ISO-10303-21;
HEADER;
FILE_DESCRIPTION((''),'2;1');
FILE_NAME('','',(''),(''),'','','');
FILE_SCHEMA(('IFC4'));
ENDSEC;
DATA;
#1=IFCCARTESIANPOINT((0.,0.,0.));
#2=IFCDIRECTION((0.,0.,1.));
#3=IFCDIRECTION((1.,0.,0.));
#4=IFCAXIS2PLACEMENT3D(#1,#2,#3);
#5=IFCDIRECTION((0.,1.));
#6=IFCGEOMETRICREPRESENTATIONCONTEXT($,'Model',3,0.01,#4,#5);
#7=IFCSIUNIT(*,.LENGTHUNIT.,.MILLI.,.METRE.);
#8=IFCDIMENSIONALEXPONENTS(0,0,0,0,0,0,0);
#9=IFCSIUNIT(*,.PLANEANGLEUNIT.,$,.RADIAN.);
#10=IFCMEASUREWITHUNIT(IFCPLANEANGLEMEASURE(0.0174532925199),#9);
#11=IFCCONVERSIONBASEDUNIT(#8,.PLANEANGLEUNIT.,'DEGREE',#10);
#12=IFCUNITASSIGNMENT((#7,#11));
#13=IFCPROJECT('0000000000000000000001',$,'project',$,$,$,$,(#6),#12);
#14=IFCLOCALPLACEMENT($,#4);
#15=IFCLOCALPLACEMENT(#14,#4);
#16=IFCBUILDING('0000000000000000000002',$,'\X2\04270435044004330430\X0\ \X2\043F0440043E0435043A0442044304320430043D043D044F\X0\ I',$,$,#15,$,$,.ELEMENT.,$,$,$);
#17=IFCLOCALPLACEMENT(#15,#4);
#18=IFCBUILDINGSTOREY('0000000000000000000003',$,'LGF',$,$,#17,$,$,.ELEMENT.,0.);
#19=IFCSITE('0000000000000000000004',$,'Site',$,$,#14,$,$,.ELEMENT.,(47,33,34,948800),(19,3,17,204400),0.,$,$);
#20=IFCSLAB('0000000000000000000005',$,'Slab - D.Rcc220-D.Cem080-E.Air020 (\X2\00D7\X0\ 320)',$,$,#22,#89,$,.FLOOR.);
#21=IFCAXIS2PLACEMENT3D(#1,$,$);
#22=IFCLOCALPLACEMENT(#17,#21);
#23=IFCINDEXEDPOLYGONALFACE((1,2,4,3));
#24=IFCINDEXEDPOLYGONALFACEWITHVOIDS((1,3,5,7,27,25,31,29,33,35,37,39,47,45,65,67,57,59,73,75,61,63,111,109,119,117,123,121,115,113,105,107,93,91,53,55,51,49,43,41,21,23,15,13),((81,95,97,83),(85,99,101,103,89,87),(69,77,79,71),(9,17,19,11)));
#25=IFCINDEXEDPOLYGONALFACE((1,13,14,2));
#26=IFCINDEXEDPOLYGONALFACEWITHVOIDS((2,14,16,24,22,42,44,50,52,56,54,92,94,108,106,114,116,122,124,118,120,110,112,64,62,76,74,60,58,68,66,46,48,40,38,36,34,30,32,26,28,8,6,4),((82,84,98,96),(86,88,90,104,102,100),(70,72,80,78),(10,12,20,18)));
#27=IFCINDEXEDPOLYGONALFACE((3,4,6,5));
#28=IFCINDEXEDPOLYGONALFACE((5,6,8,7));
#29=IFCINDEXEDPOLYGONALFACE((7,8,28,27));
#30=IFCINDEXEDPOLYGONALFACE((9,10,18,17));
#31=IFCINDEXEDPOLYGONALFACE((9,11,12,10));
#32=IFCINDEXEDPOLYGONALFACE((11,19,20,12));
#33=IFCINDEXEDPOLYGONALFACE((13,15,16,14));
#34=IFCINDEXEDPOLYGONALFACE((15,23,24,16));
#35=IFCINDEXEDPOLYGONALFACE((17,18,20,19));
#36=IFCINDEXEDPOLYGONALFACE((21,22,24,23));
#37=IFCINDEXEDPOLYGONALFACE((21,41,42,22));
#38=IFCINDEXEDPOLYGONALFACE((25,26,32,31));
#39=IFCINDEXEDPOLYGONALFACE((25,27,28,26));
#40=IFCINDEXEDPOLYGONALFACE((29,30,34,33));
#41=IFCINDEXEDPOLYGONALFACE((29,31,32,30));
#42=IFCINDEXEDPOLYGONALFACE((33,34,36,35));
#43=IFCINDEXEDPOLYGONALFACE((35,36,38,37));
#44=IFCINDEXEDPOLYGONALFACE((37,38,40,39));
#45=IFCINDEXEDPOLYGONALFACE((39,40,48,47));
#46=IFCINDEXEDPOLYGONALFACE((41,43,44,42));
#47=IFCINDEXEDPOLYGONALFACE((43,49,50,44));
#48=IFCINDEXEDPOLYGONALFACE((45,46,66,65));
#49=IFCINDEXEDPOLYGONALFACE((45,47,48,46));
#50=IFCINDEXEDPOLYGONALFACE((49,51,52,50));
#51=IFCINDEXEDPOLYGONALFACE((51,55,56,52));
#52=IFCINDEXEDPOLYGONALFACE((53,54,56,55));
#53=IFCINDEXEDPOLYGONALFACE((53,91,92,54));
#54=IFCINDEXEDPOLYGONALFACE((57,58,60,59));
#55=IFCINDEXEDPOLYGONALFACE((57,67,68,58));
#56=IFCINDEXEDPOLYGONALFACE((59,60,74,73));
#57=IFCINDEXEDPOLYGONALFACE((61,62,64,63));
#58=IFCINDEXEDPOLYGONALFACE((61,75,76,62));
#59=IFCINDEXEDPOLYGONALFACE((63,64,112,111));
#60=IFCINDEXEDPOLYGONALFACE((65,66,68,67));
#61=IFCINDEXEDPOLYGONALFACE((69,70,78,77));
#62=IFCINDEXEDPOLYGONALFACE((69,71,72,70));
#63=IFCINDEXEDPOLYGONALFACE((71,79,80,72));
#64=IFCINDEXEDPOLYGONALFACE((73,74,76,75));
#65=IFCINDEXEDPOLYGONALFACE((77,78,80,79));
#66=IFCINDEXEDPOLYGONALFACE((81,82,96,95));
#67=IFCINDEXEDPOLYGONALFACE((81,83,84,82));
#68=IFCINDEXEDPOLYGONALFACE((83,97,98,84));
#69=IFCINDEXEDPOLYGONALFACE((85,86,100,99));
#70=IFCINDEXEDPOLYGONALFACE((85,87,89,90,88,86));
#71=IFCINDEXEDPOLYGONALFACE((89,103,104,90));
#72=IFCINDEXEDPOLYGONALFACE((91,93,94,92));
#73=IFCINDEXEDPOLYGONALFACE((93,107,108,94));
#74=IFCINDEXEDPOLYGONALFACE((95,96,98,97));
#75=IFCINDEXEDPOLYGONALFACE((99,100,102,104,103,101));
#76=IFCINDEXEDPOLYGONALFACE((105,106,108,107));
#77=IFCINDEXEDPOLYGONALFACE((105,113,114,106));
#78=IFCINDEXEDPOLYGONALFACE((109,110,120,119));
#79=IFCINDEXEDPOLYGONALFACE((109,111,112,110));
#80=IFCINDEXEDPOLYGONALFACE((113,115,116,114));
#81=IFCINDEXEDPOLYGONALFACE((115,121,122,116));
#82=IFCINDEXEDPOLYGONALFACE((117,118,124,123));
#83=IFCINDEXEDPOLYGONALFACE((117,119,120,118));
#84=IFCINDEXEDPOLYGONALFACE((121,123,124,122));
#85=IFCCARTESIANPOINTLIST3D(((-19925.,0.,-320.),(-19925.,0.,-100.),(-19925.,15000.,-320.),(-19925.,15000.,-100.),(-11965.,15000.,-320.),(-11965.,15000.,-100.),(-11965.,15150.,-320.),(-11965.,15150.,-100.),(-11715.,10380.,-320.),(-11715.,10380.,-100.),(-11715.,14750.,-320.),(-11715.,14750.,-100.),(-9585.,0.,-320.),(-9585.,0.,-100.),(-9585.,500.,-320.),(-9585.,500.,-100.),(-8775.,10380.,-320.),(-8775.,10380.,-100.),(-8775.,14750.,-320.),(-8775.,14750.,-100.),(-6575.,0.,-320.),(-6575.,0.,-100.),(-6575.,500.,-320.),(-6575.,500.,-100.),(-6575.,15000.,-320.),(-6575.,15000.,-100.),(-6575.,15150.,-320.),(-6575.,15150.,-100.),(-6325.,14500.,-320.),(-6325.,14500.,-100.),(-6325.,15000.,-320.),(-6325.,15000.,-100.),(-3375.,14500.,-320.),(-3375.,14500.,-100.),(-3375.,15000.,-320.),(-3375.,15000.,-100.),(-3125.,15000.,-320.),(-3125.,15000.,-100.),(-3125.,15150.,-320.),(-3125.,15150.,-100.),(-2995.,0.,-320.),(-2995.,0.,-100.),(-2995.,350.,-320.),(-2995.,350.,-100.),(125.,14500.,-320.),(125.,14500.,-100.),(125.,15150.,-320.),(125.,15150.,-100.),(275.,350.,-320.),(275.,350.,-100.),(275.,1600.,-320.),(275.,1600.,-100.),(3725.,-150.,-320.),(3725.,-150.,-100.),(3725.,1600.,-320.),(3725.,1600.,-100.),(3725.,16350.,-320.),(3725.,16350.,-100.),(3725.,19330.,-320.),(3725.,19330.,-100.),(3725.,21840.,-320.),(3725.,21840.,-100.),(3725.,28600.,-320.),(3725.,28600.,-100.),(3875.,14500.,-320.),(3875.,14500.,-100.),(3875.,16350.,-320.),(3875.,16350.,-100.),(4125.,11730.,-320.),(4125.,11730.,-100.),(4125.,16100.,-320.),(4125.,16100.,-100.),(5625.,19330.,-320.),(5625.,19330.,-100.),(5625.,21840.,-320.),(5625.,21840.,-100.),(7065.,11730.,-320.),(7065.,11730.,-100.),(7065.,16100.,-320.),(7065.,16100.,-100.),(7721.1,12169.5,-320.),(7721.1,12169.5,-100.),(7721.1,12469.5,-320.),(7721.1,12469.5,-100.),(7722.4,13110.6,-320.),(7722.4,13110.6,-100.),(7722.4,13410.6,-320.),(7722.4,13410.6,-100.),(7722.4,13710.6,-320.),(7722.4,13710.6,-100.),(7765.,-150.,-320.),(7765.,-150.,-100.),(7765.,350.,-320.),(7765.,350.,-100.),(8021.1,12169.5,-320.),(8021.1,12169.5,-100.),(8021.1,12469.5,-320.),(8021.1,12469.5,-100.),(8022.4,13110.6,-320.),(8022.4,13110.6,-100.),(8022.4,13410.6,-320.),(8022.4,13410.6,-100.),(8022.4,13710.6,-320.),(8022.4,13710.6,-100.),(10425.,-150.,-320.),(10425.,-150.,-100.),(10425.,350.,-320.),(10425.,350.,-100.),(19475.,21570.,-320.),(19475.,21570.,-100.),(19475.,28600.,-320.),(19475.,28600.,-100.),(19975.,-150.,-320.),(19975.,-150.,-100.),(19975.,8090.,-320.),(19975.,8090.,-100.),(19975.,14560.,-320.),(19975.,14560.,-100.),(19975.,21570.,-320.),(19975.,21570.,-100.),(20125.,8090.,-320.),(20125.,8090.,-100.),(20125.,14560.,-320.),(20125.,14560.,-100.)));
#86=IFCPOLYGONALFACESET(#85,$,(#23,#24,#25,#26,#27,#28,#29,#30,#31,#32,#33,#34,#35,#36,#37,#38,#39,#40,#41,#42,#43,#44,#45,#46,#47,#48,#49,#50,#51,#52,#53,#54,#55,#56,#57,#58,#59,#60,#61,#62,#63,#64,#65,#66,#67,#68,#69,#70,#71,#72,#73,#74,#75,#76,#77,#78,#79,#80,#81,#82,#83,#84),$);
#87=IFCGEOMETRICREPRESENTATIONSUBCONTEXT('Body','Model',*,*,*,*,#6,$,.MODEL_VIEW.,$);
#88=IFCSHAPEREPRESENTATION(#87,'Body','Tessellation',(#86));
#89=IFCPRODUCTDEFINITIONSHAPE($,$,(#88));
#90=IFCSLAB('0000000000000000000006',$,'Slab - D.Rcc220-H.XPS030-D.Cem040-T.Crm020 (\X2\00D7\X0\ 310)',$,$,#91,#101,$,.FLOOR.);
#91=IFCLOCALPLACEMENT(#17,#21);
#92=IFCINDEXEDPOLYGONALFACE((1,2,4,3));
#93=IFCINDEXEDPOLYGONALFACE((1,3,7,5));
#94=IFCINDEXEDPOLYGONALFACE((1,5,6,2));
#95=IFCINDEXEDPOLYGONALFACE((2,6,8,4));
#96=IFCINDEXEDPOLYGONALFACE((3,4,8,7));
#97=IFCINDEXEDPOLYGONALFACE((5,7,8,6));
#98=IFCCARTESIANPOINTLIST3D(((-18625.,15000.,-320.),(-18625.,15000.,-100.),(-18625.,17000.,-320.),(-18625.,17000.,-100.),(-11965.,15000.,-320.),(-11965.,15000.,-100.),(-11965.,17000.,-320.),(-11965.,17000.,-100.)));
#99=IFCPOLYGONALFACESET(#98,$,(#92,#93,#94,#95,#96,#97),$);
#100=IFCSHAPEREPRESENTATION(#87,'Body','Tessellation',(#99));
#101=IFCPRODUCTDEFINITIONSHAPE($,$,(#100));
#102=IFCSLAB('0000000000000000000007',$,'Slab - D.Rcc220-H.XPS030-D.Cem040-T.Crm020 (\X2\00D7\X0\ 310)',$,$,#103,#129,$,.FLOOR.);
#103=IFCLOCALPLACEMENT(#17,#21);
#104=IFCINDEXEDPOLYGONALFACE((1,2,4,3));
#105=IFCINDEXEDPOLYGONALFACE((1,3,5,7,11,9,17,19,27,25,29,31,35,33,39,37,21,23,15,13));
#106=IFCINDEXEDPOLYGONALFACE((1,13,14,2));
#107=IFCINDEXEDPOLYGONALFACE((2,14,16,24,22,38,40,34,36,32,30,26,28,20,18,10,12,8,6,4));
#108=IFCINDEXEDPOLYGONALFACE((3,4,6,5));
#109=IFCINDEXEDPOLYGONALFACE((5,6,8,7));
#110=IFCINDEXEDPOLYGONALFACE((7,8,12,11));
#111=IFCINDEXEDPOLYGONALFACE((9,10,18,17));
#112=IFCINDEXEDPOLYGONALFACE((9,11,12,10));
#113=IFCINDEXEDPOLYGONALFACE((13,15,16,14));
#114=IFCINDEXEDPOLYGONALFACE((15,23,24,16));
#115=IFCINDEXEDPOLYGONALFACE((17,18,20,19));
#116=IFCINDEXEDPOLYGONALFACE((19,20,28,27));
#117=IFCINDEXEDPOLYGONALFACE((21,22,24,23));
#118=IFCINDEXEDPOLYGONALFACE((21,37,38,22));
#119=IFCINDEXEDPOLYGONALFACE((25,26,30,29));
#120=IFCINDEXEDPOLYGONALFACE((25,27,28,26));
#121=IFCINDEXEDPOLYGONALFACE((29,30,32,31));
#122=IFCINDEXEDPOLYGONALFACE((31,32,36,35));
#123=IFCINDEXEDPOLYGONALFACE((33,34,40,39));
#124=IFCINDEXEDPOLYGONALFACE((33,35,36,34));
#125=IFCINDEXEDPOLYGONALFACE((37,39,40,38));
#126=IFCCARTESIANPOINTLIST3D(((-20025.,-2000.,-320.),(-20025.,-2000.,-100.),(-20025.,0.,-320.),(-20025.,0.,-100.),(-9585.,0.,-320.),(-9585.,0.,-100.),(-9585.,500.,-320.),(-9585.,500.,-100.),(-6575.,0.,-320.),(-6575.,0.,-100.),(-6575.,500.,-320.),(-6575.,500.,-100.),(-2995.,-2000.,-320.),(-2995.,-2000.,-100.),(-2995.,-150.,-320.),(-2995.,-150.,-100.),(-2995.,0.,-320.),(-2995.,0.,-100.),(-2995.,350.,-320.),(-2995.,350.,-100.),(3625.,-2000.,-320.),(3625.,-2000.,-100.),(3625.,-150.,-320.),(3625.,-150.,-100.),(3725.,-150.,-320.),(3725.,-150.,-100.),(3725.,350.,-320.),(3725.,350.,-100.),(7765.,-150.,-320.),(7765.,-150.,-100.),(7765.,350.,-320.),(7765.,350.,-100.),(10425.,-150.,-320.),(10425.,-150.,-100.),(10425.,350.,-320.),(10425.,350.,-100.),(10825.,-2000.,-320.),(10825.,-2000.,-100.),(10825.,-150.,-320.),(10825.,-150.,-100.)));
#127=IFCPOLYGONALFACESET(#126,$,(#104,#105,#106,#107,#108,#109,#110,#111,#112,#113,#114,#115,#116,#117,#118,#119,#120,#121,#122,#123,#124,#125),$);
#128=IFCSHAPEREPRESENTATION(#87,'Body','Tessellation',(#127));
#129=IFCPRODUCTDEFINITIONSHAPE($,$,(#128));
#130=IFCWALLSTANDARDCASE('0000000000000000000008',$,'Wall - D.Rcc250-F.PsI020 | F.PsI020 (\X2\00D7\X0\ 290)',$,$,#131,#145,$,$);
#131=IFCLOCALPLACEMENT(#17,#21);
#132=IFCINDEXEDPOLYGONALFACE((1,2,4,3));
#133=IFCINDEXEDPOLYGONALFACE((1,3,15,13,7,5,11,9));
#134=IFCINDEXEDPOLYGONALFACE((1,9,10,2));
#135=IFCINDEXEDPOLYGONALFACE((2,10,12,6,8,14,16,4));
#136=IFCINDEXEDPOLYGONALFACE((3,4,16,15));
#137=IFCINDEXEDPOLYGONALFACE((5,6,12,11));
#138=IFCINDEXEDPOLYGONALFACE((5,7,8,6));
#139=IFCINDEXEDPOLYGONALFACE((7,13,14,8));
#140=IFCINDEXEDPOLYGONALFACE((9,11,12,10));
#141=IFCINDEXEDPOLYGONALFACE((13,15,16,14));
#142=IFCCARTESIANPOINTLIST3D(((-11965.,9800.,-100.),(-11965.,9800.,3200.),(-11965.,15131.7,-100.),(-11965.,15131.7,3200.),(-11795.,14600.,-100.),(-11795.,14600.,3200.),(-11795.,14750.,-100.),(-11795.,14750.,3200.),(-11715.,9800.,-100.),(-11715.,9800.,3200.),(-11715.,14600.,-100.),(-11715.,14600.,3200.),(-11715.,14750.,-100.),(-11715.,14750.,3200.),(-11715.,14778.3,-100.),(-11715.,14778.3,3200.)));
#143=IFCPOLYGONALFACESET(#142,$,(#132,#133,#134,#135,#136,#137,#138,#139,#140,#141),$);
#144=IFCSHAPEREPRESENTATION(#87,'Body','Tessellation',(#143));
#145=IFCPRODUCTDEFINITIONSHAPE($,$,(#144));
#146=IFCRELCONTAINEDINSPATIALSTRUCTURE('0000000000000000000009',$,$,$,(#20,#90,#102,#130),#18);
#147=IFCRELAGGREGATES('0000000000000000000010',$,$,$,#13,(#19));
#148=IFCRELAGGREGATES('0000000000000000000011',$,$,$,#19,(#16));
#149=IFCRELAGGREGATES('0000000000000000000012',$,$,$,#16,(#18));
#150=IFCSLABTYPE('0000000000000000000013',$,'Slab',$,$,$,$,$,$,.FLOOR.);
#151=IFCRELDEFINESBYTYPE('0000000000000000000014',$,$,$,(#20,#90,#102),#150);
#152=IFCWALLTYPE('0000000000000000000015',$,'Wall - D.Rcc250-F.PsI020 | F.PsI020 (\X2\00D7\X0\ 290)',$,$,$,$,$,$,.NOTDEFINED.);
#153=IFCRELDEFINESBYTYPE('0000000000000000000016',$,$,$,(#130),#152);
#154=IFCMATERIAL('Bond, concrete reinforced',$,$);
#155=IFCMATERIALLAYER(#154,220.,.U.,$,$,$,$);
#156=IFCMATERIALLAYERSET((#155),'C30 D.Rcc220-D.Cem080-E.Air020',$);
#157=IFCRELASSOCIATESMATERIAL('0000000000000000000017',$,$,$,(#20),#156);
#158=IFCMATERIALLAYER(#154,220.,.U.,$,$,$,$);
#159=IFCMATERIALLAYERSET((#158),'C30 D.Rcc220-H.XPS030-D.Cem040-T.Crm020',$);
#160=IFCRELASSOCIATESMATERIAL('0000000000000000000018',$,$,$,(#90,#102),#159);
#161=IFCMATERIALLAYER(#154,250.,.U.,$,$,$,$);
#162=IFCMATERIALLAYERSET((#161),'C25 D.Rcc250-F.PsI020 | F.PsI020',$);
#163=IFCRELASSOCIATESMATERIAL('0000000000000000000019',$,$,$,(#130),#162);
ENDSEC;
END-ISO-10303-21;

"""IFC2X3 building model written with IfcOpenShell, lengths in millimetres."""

from ifc_helpers import new_model, entity, si_unit, converted_unit, direction, frame, origin_with_axes, origin_2d_with_axis, place, context, subcontext, project, spatial, polyline, rectangle, outline, extrude, material, layer, layer_set, layer_usage, type_object, element, save


model = new_model("IFC2X3")

# Units and contexts
model_context = context("Model", 3, precision=0.01, world=origin_with_axes(), true_north=direction((0.0, 1.0)))
body_context = subcontext(model_context, "Body", "Model", "MODEL_VIEW")
ifc_project = project(units=[si_unit("LENGTHUNIT", "METRE", prefix="MILLI"), converted_unit("PLANEANGLEUNIT", "DEGREE", entity("IfcPlaneAngleMeasure", 0.0174532925199), si_unit("PLANEANGLEUNIT", "RADIAN"), dimensions=[0, 0, 0, 0, 0, 0, 0])], contexts=[model_context])

# Site, building, storey
site_placement = place(None, origin_with_axes())
site = spatial("IfcSite", under=ifc_project, at=site_placement, Name="Site", CompositionType="ELEMENT", RefLatitude=(47, 33, 34, 948800), RefLongitude=(19, 3, 17, 204400), RefElevation=0.0)
building_placement = place(site_placement, origin_with_axes())
building = spatial("IfcBuilding", under=site, at=building_placement, Name="Черга проектування I", CompositionType="ELEMENT")
storey_placement = place(building_placement, origin_with_axes())
storey = spatial("IfcBuildingStorey", under=building, at=storey_placement, Name="LGF", CompositionType="ELEMENT", Elevation=0.0)

# Shared definitions
ifc_material = material(Name="Bond, concrete reinforced")

# Slab, openings
ifc_layer_1 = layer(ifc_material, 220.0, ventilated="UNKNOWN")
ifc_layer_set_1 = layer_set([ifc_layer_1], Name="C30 D.Rcc220-D.Cem080-E.Air020")
ifc_layer_usage_1 = layer_usage(ifc_layer_set_1, "AXIS3", "NEGATIVE", 220.0)
slab_type = type_object("IfcSlabType", Name="Slab", PredefinedType="FLOOR")
slab_1_placement = place(storey_placement, frame((-19925.0, 0.0, -100.0), z_axis=(0.0, 0.0, 1.0), x_axis=(1.0, 0.0, 0.0)))
slab_1 = element("IfcSlab", 1, at=slab_1_placement, inside=storey, type_object=slab_type, material=ifc_layer_usage_1, Name="Slab - D.Rcc220-D.Cem080-E.Air020 (× 320)", PredefinedType="FLOOR", context=body_context, shape_type="SweptSolid", body=[
    extrude(outline(polyline([(0.0, 0.0), (10340.0, 0.0), (10340.0, 500.0), (13350.0, 500.0), (13350.0, 0.0), (16930.0, 0.0), (16930.0, 350.0), (20200.0, 350.0), (20200.0, 1600.0), (23650.0, 1600.0), (23650.0, -150.0), (27690.0, -150.0), (27690.0, 350.0), (30350.0, 350.0), (30350.0, -150.0), (39900.0, -150.0), (39900.0, 8090.0), (40050.0, 8090.0), (40050.0, 14560.0), (39900.0, 14560.0), (39900.0, 21570.0), (39400.0, 21570.0), (39400.0, 28600.0), (23650.0, 28600.0), (23650.0, 21840.0), (25550.0, 21840.0), (25550.0, 19330.0), (23650.0, 19330.0), (23650.0, 16350.0), (23800.0, 16350.0), (23800.0, 14500.0), (20050.0, 14500.0), (20050.0, 15150.0), (16800.0, 15150.0), (16800.0, 15000.0), (16550.0, 15000.0), (16550.0, 14500.0), (13600.0, 14500.0), (13600.0, 15000.0), (13350.0, 15000.0), (13350.0, 15150.0), (7960.0, 15150.0), (7960.0, 15000.0), (0.0, 15000.0), (0.0, 0.0)])), frame((0.0, 0.0, -220.0), z_axis=(0.0, 0.0, 1.0), x_axis=(1.0, 0.0, 0.0)), (0.0, 0.0, 1.0), 220.0),
])
opening_1_placement = place(slab_1_placement, frame((19925.0, 0.0, 100.0), z_axis=(0.0, 0.0, 1.0), x_axis=(1.0, 0.0, 0.0)))
element("IfcOpeningElement", 2, at=opening_1_placement, cuts=slab_1, ObjectType="OPENING", context=body_context, shape_type="SweptSolid", body=[
    extrude(rectangle(XDim=300.0, YDim=300.0, at=origin_2d_with_axis()), frame((7872.4, 13560.6, 320.0), z_axis=(0.0, 0.0, 1.0), x_axis=(1.0, 0.0, 0.0)), (0.0, 0.0, -1.0), 960.0),
])
opening_2_placement = place(slab_1_placement, frame((19925.0, 0.0, 100.0), z_axis=(0.0, 0.0, 1.0), x_axis=(1.0, 0.0, 0.0)))
element("IfcOpeningElement", 3, at=opening_2_placement, cuts=slab_1, ObjectType="OPENING", context=body_context, shape_type="SweptSolid", body=[
    extrude(rectangle(XDim=300.0, YDim=300.0, at=origin_2d_with_axis()), frame((7871.1, 12319.5, 320.0), z_axis=(0.0, 0.0, 1.0), x_axis=(1.0, 0.0, 0.0)), (0.0, 0.0, -1.0), 960.0),
])
opening_3_placement = place(slab_1_placement, frame((19925.0, 0.0, 100.0), z_axis=(0.0, 0.0, 1.0), x_axis=(1.0, 0.0, 0.0)))
element("IfcOpeningElement", 4, at=opening_3_placement, cuts=slab_1, ObjectType="OPENING", context=body_context, shape_type="SweptSolid", body=[
    extrude(rectangle(XDim=300.0, YDim=300.0, at=origin_2d_with_axis()), frame((7872.4, 13260.6, 320.0), z_axis=(0.0, 0.0, 1.0), x_axis=(1.0, 0.0, 0.0)), (0.0, 0.0, -1.0), 960.0),
])
opening_4_placement = place(slab_1_placement, frame((19925.0, 0.0, 100.0), z_axis=(0.0, 0.0, 1.0), x_axis=(1.0, 0.0, 0.0)))
element("IfcOpeningElement", 5, at=opening_4_placement, cuts=slab_1, ObjectType="OPENING", context=body_context, shape_type="SweptSolid", body=[
    extrude(rectangle(XDim=2940.0, YDim=4370.0, at=origin_2d_with_axis()), frame((5595.0, 13915.0, 320.0), z_axis=(0.0, 0.0, 1.0), x_axis=(1.0, 0.0, 0.0)), (0.0, 0.0, -1.0), 960.0),
])
opening_5_placement = place(slab_1_placement, frame((19925.0, 0.0, 100.0), z_axis=(0.0, 0.0, 1.0), x_axis=(1.0, 0.0, 0.0)))
element("IfcOpeningElement", 6, at=opening_5_placement, cuts=slab_1, ObjectType="OPENING", context=body_context, shape_type="SweptSolid", body=[
    extrude(rectangle(XDim=2940.0, YDim=4370.0, at=origin_2d_with_axis()), frame((-10245.0, 12565.0, 320.0), z_axis=(0.0, 0.0, 1.0), x_axis=(1.0, 0.0, 0.0)), (0.0, 0.0, -1.0), 960.0),
])

# Slabs
ifc_layer_2 = layer(ifc_material, 220.0, ventilated="UNKNOWN")
ifc_layer_set_2 = layer_set([ifc_layer_2], Name="C30 D.Rcc220-H.XPS030-D.Cem040-T.Crm020")
ifc_layer_usage_2 = layer_usage(ifc_layer_set_2, "AXIS3", "NEGATIVE", 220.0)
slab_2_placement = place(storey_placement, frame((-18625.0, 15000.0, -100.0), z_axis=(0.0, 0.0, 1.0), x_axis=(1.0, 0.0, 0.0)))
element("IfcSlab", 7, at=slab_2_placement, inside=storey, type_object=slab_type, material=ifc_layer_usage_2, Name="Slab - D.Rcc220-H.XPS030-D.Cem040-T.Crm020 (× 310)", PredefinedType="FLOOR", context=body_context, shape_type="SweptSolid", body=[
    extrude(outline(polyline([(0.0, 0.0), (6660.0, 0.0), (6660.0, 2000.0), (0.0, 2000.0), (0.0, 0.0)])), frame((0.0, 0.0, -220.0), z_axis=(0.0, 0.0, 1.0), x_axis=(1.0, 0.0, 0.0)), (0.0, 0.0, 1.0), 220.0),
])
ifc_layer_usage_3 = layer_usage(ifc_layer_set_2, "AXIS3", "NEGATIVE", 220.0)
slab_3_placement = place(storey_placement, frame((-20025.0, -2000.0, -100.0), z_axis=(0.0, 0.0, 1.0), x_axis=(1.0, 0.0, 0.0)))
element("IfcSlab", 8, at=slab_3_placement, inside=storey, type_object=slab_type, material=ifc_layer_usage_3, Name="Slab - D.Rcc220-H.XPS030-D.Cem040-T.Crm020 (× 310)", PredefinedType="FLOOR", context=body_context, shape_type="SweptSolid", body=[
    extrude(outline(polyline([(0.0, 0.0), (17030.0, 0.0), (17030.0, 1850.0), (23650.0, 1850.0), (23650.0, 0.0), (30850.0, 0.0), (30850.0, 1850.0), (30450.0, 1850.0), (30450.0, 2350.0), (27790.0, 2350.0), (27790.0, 1850.0), (23750.0, 1850.0), (23750.0, 2350.0), (17030.0, 2350.0), (17030.0, 2000.0), (13450.0, 2000.0), (13450.0, 2500.0), (10440.0, 2500.0), (10440.0, 2000.0), (0.0, 2000.0), (0.0, 0.0)])), frame((0.0, 0.0, -220.0), z_axis=(0.0, 0.0, 1.0), x_axis=(1.0, 0.0, 0.0)), (0.0, 0.0, 1.0), 220.0),
])

# Wall, opening
ifc_layer_3 = layer(ifc_material, 250.0, ventilated="UNKNOWN")
ifc_layer_set_3 = layer_set([ifc_layer_3], Name="C25 D.Rcc250-F.PsI020 | F.PsI020")
ifc_layer_usage_4 = layer_usage(ifc_layer_set_3, "AXIS2", "NEGATIVE", 0.0)
wall_type_1 = type_object("IfcWallType", Name="Wall - D.Rcc250-F.PsI020 | F.PsI020 (× 290)", PredefinedType="NOTDEFINED")
wall_1_placement = place(storey_placement, frame((-11965.0, 9800.0, -100.0), z_axis=(0.0, 0.0, 1.0), x_axis=(0.0, 1.0, 0.0)))
wall_1 = element("IfcWallStandardCase", 9, at=wall_1_placement, inside=storey, type_object=wall_type_1, material=ifc_layer_usage_4, Name="Wall - D.Rcc250-F.PsI020 | F.PsI020 (× 290)", context=body_context, shape_type="SweptSolid", body=[
    extrude(outline(polyline([(0.0, -250.0), (4978.3, -250.0), (5331.7, 0.0), (0.0, 0.0), (0.0, -250.0)])), origin_with_axes(), (0.0, 0.0, 1.0), 3300.0),
])
opening_6_placement = place(wall_1_placement, frame((-9800.0, -11965.0, 100.0), z_axis=(0.0, 0.0, 1.0), x_axis=(0.0, -1.0, 0.0)))
element("IfcOpeningElement", 10, at=opening_6_placement, cuts=wall_1, ObjectType="OPENING", context=body_context, shape_type="SweptSolid", body=[
    extrude(rectangle(XDim=150.0, YDim=3300.0, at=origin_2d_with_axis()), frame((-11795.0, 14675.0, 1550.0), z_axis=(1.0, 0.0, 0.0), x_axis=(0.0, 1.0, 0.0)), (0.0, 0.0, 1.0), 80.0),
])

save(model, "model.ifc")
